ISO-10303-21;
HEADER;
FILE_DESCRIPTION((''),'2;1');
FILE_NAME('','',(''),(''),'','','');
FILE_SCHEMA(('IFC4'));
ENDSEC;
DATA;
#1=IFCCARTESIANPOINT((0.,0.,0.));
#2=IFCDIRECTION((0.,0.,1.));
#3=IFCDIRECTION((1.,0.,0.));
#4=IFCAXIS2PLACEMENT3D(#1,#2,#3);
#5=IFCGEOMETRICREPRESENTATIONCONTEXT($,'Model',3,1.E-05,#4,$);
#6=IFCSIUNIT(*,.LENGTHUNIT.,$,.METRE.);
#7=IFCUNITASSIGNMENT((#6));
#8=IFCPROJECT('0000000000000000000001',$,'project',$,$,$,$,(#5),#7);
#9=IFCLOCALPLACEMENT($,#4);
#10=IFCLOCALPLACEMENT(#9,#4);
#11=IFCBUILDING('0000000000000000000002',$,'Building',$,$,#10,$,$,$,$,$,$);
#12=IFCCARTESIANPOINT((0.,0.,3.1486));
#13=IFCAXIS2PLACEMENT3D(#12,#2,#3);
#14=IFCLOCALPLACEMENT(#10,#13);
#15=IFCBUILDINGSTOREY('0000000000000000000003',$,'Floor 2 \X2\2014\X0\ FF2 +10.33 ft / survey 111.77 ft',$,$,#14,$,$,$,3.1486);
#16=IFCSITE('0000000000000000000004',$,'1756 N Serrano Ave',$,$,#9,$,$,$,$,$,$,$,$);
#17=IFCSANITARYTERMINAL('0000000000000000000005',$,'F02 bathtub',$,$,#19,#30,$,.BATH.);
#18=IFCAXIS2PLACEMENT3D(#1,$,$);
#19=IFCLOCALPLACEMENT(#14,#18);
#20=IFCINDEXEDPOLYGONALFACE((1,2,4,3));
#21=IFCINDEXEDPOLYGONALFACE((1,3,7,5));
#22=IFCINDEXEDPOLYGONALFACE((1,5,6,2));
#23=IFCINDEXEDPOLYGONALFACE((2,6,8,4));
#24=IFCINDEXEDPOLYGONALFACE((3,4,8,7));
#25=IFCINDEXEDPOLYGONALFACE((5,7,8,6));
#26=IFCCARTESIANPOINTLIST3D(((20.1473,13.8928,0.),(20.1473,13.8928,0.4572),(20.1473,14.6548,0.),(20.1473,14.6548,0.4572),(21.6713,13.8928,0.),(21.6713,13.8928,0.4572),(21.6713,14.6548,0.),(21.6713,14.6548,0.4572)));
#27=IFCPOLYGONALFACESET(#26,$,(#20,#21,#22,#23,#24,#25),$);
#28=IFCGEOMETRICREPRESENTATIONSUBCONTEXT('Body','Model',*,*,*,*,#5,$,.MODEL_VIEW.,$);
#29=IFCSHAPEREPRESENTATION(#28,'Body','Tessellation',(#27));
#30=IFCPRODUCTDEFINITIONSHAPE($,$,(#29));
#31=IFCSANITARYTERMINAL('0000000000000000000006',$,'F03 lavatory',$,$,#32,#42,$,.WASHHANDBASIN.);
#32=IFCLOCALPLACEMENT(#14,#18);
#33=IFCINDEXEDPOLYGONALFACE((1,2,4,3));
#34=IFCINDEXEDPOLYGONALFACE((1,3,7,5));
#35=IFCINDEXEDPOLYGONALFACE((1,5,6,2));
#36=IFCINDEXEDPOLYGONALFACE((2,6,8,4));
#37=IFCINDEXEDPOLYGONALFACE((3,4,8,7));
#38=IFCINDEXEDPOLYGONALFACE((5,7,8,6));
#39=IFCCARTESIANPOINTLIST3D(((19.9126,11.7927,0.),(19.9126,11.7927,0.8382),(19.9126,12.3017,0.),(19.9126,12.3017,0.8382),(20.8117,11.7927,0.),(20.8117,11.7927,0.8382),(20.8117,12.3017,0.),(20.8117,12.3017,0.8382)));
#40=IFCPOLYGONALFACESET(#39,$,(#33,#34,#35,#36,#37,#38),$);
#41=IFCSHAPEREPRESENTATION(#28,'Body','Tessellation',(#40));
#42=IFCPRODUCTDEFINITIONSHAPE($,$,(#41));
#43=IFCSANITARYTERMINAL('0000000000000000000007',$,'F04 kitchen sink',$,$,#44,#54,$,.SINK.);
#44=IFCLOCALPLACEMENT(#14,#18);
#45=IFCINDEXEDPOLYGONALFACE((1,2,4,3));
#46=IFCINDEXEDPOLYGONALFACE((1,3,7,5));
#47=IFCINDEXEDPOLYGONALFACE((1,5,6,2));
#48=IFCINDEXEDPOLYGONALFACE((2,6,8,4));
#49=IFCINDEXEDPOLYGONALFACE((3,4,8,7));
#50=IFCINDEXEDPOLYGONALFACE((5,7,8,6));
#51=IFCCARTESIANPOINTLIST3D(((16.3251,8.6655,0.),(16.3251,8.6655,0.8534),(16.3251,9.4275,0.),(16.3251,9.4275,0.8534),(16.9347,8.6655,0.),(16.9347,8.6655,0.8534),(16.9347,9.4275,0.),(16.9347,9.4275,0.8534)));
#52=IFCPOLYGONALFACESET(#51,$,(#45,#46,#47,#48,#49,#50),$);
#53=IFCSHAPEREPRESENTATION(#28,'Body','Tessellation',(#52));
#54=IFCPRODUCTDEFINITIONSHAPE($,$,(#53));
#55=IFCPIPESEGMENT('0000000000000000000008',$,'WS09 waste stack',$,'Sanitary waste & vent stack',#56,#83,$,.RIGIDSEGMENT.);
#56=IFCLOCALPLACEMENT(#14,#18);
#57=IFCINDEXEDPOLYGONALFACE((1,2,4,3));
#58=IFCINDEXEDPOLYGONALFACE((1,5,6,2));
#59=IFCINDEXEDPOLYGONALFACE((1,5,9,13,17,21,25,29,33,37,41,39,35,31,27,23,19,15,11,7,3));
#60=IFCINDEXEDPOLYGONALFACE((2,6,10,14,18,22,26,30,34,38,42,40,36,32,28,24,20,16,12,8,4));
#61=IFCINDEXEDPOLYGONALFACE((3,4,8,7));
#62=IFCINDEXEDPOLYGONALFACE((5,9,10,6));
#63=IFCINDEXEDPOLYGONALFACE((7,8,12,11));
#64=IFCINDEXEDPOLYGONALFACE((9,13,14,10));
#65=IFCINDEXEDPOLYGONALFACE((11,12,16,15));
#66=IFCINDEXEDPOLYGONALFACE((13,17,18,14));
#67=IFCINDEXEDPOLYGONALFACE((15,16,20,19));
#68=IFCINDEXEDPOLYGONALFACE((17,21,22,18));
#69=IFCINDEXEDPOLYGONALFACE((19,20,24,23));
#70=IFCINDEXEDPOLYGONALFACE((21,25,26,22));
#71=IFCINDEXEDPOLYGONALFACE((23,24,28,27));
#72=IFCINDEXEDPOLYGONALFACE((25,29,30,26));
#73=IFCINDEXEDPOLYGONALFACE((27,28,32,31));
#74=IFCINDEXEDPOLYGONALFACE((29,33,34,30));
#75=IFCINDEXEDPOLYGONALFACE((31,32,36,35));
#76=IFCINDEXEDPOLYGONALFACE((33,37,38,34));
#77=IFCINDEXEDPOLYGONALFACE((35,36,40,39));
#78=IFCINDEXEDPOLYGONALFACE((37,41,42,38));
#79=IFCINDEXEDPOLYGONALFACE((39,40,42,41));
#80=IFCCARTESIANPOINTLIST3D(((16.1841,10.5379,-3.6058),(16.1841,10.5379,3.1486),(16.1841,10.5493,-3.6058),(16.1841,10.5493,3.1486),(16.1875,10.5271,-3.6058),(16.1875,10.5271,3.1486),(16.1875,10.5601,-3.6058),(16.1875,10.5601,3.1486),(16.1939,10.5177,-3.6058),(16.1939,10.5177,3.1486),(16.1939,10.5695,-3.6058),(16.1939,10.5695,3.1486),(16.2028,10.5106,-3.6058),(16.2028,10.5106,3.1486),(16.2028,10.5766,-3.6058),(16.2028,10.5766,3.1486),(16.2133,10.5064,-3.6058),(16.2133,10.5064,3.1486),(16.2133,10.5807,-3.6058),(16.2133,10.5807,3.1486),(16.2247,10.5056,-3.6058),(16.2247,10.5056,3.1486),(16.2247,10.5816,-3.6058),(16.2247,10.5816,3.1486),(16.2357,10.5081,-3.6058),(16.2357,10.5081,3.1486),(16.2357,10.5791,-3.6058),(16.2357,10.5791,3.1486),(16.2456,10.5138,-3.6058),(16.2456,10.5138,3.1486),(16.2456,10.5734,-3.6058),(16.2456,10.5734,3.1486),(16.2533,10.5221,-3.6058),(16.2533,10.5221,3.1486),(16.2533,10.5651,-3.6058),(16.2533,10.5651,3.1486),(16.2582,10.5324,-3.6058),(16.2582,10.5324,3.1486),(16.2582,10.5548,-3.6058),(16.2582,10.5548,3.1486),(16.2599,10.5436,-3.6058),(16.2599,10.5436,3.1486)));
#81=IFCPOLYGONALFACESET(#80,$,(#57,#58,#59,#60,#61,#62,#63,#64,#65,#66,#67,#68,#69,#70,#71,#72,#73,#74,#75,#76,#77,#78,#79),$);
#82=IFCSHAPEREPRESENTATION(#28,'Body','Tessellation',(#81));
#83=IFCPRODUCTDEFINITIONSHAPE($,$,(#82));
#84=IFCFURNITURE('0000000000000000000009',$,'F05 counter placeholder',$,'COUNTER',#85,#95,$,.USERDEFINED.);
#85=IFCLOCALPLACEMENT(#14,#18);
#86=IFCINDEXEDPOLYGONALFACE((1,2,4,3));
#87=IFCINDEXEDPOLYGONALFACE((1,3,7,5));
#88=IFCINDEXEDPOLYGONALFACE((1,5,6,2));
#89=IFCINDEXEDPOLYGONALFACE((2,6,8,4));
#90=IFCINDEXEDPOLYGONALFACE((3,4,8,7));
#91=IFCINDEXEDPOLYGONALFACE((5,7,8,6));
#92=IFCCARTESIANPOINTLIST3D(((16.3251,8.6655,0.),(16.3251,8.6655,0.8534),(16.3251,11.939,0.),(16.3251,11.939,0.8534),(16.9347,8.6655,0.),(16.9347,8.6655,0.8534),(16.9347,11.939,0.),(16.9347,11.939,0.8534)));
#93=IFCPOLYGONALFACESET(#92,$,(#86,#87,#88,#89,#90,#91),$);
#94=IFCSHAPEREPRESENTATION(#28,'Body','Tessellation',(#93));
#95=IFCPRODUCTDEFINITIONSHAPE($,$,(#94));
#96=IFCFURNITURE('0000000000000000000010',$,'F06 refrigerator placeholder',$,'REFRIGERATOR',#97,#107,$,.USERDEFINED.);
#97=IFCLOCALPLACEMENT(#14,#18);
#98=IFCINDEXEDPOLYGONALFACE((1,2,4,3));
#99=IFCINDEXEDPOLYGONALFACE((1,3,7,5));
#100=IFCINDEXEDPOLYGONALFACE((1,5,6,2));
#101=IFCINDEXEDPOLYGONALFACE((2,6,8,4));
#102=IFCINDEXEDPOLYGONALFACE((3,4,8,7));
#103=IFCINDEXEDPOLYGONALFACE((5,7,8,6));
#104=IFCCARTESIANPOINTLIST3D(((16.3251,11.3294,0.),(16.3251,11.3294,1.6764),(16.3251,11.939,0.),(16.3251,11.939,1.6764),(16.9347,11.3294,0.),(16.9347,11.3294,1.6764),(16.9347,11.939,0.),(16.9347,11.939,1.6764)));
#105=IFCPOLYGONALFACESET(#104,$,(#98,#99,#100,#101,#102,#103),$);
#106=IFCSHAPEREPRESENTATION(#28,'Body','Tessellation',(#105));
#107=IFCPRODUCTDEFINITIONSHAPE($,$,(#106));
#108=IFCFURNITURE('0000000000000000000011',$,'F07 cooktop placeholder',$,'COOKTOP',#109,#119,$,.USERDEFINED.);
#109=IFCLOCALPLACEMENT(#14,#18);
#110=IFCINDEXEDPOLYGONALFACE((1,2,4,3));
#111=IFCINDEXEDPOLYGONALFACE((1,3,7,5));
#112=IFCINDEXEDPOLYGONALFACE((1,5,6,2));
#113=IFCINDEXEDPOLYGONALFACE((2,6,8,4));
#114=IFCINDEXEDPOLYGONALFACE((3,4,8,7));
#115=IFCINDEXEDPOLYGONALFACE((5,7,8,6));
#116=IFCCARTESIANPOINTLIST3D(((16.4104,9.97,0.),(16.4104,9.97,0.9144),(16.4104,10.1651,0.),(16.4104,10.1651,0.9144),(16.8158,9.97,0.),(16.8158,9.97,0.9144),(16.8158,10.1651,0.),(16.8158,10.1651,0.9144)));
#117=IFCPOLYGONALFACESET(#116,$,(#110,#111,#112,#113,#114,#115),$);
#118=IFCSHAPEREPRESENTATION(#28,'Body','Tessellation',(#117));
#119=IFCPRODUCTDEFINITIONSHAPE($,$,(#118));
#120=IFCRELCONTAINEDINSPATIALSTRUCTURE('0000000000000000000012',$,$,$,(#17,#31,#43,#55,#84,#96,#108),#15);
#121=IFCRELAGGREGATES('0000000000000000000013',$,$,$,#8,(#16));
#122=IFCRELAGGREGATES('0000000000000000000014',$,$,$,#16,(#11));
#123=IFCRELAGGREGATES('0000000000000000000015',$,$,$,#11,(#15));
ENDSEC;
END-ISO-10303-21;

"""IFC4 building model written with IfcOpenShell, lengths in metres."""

from ifc_helpers import new_model, entity, si_unit, frame, frame_2d, origin, origin_with_axes, place, context, subcontext, project, spatial, rectangle, extrude, element, save


model = new_model("IFC4")

# Units and contexts
model_context = context("Model", 3, precision=1e-05, world=origin_with_axes())
body_context = subcontext(model_context, "Body", "Model", "MODEL_VIEW")
ifc_project = project(units=[si_unit("LENGTHUNIT", "METRE")], contexts=[model_context])

# Site, building, storey
site_placement = place(None, origin_with_axes())
site = spatial("IfcSite", under=ifc_project, at=site_placement, Name="1756 N Serrano Ave")
building_placement = place(site_placement, origin_with_axes())
building = spatial("IfcBuilding", under=site, at=building_placement, Name="Building")
storey_placement = place(building_placement, frame((0.0, 0.0, 3.1486), z_axis=(0.0, 0.0, 1.0), x_axis=(1.0, 0.0, 0.0)))
storey = spatial("IfcBuildingStorey", under=building, at=storey_placement, Name="Floor 2 — FF2 +10.33 ft / survey 111.77 ft", Elevation=3.1486)

# Sanitary terminals
sanitary_terminal_1_placement = place(storey_placement, frame((20.1473, 14.2738, 0.0), z_axis=(0.0, 0.0, 1.0), x_axis=(1.0, 0.0, 0.0)))
element("IfcSanitaryTerminal", 1, at=sanitary_terminal_1_placement, inside=storey, Name="F02 bathtub", PredefinedType="BATH", context=body_context, shape_type="SweptSolid", body=[
    extrude(rectangle(XDim=1.524, YDim=0.762, at=frame_2d((0.762, 0.0))), origin(), (0.0, 0.0, 1.0), 0.4572),
])
sanitary_terminal_2_placement = place(storey_placement, frame((19.9126, 12.0472, 0.0), z_axis=(0.0, 0.0, 1.0), x_axis=(1.0, 0.0, 0.0)))
element("IfcSanitaryTerminal", 2, at=sanitary_terminal_2_placement, inside=storey, Name="F03 lavatory", PredefinedType="WASHHANDBASIN", context=body_context, shape_type="SweptSolid", body=[
    extrude(rectangle(XDim=0.8992, YDim=0.509, at=frame_2d((0.4496, 0.0))), origin(), (0.0, 0.0, 1.0), 0.8382),
])
sanitary_terminal_3_placement = place(storey_placement, frame((16.3251, 9.0465, 0.0), z_axis=(0.0, 0.0, 1.0), x_axis=(1.0, 0.0, 0.0)))
element("IfcSanitaryTerminal", 3, at=sanitary_terminal_3_placement, inside=storey, Name="F04 kitchen sink", PredefinedType="SINK", context=body_context, shape_type="SweptSolid", body=[
    extrude(rectangle(XDim=0.6096, YDim=0.762, at=frame_2d((0.3048, 0.0))), origin(), (0.0, 0.0, 1.0), 0.8534),
])

# Pipe segment
pipe_segment_1_placement = place(storey_placement, frame((0.0, 0.0, -3.1486), z_axis=(0.0, 0.0, 1.0), x_axis=(1.0, 0.0, 0.0)))
element("IfcPipeSegment", 4, at=pipe_segment_1_placement, inside=storey, Name="WS09 waste stack", ObjectType="Sanitary waste & vent stack", PredefinedType="RIGIDSEGMENT", context=body_context, shape_type="AdvancedSweptSolid", body=[
    entity("IfcSweptDiskSolid", entity("IfcPolyline", [entity("IfcCartesianPoint", [16.2218, 10.5436, -0.4572]), entity("IfcCartesianPoint", [16.2218, 10.5436, 6.2972])]), 0.0381),
])

# Furniture
furniture_1_placement = place(storey_placement, frame((16.3251, 10.3022, 0.0), z_axis=(0.0, 0.0, 1.0), x_axis=(1.0, 0.0, 0.0)))
element("IfcFurniture", 5, at=furniture_1_placement, inside=storey, Name="F05 counter placeholder", ObjectType="COUNTER", PredefinedType="USERDEFINED", context=body_context, shape_type="SweptSolid", body=[
    extrude(rectangle(XDim=0.6096, YDim=3.2736, at=frame_2d((0.3048, 0.0))), origin(), (0.0, 0.0, 1.0), 0.8534),
])
furniture_2_placement = place(storey_placement, frame((16.3251, 11.6342, 0.0), z_axis=(0.0, 0.0, 1.0), x_axis=(1.0, 0.0, 0.0)))
element("IfcFurniture", 6, at=furniture_2_placement, inside=storey, Name="F06 refrigerator placeholder", ObjectType="REFRIGERATOR", PredefinedType="USERDEFINED", context=body_context, shape_type="SweptSolid", body=[
    extrude(rectangle(XDim=0.6096, YDim=0.6096, at=frame_2d((0.3048, 0.0))), origin(), (0.0, 0.0, 1.0), 1.6764),
])
furniture_3_placement = place(storey_placement, frame((16.4104, 10.0675, 0.0), z_axis=(0.0, 0.0, 1.0), x_axis=(1.0, 0.0, 0.0)))
element("IfcFurniture", 7, at=furniture_3_placement, inside=storey, Name="F07 cooktop placeholder", ObjectType="COOKTOP", PredefinedType="USERDEFINED", context=body_context, shape_type="SweptSolid", body=[
    extrude(rectangle(XDim=0.4054, YDim=0.1951, at=frame_2d((0.2027, 0.0))), origin(), (0.0, 0.0, 1.0), 0.9144),
])

save(model, "model.ifc")
